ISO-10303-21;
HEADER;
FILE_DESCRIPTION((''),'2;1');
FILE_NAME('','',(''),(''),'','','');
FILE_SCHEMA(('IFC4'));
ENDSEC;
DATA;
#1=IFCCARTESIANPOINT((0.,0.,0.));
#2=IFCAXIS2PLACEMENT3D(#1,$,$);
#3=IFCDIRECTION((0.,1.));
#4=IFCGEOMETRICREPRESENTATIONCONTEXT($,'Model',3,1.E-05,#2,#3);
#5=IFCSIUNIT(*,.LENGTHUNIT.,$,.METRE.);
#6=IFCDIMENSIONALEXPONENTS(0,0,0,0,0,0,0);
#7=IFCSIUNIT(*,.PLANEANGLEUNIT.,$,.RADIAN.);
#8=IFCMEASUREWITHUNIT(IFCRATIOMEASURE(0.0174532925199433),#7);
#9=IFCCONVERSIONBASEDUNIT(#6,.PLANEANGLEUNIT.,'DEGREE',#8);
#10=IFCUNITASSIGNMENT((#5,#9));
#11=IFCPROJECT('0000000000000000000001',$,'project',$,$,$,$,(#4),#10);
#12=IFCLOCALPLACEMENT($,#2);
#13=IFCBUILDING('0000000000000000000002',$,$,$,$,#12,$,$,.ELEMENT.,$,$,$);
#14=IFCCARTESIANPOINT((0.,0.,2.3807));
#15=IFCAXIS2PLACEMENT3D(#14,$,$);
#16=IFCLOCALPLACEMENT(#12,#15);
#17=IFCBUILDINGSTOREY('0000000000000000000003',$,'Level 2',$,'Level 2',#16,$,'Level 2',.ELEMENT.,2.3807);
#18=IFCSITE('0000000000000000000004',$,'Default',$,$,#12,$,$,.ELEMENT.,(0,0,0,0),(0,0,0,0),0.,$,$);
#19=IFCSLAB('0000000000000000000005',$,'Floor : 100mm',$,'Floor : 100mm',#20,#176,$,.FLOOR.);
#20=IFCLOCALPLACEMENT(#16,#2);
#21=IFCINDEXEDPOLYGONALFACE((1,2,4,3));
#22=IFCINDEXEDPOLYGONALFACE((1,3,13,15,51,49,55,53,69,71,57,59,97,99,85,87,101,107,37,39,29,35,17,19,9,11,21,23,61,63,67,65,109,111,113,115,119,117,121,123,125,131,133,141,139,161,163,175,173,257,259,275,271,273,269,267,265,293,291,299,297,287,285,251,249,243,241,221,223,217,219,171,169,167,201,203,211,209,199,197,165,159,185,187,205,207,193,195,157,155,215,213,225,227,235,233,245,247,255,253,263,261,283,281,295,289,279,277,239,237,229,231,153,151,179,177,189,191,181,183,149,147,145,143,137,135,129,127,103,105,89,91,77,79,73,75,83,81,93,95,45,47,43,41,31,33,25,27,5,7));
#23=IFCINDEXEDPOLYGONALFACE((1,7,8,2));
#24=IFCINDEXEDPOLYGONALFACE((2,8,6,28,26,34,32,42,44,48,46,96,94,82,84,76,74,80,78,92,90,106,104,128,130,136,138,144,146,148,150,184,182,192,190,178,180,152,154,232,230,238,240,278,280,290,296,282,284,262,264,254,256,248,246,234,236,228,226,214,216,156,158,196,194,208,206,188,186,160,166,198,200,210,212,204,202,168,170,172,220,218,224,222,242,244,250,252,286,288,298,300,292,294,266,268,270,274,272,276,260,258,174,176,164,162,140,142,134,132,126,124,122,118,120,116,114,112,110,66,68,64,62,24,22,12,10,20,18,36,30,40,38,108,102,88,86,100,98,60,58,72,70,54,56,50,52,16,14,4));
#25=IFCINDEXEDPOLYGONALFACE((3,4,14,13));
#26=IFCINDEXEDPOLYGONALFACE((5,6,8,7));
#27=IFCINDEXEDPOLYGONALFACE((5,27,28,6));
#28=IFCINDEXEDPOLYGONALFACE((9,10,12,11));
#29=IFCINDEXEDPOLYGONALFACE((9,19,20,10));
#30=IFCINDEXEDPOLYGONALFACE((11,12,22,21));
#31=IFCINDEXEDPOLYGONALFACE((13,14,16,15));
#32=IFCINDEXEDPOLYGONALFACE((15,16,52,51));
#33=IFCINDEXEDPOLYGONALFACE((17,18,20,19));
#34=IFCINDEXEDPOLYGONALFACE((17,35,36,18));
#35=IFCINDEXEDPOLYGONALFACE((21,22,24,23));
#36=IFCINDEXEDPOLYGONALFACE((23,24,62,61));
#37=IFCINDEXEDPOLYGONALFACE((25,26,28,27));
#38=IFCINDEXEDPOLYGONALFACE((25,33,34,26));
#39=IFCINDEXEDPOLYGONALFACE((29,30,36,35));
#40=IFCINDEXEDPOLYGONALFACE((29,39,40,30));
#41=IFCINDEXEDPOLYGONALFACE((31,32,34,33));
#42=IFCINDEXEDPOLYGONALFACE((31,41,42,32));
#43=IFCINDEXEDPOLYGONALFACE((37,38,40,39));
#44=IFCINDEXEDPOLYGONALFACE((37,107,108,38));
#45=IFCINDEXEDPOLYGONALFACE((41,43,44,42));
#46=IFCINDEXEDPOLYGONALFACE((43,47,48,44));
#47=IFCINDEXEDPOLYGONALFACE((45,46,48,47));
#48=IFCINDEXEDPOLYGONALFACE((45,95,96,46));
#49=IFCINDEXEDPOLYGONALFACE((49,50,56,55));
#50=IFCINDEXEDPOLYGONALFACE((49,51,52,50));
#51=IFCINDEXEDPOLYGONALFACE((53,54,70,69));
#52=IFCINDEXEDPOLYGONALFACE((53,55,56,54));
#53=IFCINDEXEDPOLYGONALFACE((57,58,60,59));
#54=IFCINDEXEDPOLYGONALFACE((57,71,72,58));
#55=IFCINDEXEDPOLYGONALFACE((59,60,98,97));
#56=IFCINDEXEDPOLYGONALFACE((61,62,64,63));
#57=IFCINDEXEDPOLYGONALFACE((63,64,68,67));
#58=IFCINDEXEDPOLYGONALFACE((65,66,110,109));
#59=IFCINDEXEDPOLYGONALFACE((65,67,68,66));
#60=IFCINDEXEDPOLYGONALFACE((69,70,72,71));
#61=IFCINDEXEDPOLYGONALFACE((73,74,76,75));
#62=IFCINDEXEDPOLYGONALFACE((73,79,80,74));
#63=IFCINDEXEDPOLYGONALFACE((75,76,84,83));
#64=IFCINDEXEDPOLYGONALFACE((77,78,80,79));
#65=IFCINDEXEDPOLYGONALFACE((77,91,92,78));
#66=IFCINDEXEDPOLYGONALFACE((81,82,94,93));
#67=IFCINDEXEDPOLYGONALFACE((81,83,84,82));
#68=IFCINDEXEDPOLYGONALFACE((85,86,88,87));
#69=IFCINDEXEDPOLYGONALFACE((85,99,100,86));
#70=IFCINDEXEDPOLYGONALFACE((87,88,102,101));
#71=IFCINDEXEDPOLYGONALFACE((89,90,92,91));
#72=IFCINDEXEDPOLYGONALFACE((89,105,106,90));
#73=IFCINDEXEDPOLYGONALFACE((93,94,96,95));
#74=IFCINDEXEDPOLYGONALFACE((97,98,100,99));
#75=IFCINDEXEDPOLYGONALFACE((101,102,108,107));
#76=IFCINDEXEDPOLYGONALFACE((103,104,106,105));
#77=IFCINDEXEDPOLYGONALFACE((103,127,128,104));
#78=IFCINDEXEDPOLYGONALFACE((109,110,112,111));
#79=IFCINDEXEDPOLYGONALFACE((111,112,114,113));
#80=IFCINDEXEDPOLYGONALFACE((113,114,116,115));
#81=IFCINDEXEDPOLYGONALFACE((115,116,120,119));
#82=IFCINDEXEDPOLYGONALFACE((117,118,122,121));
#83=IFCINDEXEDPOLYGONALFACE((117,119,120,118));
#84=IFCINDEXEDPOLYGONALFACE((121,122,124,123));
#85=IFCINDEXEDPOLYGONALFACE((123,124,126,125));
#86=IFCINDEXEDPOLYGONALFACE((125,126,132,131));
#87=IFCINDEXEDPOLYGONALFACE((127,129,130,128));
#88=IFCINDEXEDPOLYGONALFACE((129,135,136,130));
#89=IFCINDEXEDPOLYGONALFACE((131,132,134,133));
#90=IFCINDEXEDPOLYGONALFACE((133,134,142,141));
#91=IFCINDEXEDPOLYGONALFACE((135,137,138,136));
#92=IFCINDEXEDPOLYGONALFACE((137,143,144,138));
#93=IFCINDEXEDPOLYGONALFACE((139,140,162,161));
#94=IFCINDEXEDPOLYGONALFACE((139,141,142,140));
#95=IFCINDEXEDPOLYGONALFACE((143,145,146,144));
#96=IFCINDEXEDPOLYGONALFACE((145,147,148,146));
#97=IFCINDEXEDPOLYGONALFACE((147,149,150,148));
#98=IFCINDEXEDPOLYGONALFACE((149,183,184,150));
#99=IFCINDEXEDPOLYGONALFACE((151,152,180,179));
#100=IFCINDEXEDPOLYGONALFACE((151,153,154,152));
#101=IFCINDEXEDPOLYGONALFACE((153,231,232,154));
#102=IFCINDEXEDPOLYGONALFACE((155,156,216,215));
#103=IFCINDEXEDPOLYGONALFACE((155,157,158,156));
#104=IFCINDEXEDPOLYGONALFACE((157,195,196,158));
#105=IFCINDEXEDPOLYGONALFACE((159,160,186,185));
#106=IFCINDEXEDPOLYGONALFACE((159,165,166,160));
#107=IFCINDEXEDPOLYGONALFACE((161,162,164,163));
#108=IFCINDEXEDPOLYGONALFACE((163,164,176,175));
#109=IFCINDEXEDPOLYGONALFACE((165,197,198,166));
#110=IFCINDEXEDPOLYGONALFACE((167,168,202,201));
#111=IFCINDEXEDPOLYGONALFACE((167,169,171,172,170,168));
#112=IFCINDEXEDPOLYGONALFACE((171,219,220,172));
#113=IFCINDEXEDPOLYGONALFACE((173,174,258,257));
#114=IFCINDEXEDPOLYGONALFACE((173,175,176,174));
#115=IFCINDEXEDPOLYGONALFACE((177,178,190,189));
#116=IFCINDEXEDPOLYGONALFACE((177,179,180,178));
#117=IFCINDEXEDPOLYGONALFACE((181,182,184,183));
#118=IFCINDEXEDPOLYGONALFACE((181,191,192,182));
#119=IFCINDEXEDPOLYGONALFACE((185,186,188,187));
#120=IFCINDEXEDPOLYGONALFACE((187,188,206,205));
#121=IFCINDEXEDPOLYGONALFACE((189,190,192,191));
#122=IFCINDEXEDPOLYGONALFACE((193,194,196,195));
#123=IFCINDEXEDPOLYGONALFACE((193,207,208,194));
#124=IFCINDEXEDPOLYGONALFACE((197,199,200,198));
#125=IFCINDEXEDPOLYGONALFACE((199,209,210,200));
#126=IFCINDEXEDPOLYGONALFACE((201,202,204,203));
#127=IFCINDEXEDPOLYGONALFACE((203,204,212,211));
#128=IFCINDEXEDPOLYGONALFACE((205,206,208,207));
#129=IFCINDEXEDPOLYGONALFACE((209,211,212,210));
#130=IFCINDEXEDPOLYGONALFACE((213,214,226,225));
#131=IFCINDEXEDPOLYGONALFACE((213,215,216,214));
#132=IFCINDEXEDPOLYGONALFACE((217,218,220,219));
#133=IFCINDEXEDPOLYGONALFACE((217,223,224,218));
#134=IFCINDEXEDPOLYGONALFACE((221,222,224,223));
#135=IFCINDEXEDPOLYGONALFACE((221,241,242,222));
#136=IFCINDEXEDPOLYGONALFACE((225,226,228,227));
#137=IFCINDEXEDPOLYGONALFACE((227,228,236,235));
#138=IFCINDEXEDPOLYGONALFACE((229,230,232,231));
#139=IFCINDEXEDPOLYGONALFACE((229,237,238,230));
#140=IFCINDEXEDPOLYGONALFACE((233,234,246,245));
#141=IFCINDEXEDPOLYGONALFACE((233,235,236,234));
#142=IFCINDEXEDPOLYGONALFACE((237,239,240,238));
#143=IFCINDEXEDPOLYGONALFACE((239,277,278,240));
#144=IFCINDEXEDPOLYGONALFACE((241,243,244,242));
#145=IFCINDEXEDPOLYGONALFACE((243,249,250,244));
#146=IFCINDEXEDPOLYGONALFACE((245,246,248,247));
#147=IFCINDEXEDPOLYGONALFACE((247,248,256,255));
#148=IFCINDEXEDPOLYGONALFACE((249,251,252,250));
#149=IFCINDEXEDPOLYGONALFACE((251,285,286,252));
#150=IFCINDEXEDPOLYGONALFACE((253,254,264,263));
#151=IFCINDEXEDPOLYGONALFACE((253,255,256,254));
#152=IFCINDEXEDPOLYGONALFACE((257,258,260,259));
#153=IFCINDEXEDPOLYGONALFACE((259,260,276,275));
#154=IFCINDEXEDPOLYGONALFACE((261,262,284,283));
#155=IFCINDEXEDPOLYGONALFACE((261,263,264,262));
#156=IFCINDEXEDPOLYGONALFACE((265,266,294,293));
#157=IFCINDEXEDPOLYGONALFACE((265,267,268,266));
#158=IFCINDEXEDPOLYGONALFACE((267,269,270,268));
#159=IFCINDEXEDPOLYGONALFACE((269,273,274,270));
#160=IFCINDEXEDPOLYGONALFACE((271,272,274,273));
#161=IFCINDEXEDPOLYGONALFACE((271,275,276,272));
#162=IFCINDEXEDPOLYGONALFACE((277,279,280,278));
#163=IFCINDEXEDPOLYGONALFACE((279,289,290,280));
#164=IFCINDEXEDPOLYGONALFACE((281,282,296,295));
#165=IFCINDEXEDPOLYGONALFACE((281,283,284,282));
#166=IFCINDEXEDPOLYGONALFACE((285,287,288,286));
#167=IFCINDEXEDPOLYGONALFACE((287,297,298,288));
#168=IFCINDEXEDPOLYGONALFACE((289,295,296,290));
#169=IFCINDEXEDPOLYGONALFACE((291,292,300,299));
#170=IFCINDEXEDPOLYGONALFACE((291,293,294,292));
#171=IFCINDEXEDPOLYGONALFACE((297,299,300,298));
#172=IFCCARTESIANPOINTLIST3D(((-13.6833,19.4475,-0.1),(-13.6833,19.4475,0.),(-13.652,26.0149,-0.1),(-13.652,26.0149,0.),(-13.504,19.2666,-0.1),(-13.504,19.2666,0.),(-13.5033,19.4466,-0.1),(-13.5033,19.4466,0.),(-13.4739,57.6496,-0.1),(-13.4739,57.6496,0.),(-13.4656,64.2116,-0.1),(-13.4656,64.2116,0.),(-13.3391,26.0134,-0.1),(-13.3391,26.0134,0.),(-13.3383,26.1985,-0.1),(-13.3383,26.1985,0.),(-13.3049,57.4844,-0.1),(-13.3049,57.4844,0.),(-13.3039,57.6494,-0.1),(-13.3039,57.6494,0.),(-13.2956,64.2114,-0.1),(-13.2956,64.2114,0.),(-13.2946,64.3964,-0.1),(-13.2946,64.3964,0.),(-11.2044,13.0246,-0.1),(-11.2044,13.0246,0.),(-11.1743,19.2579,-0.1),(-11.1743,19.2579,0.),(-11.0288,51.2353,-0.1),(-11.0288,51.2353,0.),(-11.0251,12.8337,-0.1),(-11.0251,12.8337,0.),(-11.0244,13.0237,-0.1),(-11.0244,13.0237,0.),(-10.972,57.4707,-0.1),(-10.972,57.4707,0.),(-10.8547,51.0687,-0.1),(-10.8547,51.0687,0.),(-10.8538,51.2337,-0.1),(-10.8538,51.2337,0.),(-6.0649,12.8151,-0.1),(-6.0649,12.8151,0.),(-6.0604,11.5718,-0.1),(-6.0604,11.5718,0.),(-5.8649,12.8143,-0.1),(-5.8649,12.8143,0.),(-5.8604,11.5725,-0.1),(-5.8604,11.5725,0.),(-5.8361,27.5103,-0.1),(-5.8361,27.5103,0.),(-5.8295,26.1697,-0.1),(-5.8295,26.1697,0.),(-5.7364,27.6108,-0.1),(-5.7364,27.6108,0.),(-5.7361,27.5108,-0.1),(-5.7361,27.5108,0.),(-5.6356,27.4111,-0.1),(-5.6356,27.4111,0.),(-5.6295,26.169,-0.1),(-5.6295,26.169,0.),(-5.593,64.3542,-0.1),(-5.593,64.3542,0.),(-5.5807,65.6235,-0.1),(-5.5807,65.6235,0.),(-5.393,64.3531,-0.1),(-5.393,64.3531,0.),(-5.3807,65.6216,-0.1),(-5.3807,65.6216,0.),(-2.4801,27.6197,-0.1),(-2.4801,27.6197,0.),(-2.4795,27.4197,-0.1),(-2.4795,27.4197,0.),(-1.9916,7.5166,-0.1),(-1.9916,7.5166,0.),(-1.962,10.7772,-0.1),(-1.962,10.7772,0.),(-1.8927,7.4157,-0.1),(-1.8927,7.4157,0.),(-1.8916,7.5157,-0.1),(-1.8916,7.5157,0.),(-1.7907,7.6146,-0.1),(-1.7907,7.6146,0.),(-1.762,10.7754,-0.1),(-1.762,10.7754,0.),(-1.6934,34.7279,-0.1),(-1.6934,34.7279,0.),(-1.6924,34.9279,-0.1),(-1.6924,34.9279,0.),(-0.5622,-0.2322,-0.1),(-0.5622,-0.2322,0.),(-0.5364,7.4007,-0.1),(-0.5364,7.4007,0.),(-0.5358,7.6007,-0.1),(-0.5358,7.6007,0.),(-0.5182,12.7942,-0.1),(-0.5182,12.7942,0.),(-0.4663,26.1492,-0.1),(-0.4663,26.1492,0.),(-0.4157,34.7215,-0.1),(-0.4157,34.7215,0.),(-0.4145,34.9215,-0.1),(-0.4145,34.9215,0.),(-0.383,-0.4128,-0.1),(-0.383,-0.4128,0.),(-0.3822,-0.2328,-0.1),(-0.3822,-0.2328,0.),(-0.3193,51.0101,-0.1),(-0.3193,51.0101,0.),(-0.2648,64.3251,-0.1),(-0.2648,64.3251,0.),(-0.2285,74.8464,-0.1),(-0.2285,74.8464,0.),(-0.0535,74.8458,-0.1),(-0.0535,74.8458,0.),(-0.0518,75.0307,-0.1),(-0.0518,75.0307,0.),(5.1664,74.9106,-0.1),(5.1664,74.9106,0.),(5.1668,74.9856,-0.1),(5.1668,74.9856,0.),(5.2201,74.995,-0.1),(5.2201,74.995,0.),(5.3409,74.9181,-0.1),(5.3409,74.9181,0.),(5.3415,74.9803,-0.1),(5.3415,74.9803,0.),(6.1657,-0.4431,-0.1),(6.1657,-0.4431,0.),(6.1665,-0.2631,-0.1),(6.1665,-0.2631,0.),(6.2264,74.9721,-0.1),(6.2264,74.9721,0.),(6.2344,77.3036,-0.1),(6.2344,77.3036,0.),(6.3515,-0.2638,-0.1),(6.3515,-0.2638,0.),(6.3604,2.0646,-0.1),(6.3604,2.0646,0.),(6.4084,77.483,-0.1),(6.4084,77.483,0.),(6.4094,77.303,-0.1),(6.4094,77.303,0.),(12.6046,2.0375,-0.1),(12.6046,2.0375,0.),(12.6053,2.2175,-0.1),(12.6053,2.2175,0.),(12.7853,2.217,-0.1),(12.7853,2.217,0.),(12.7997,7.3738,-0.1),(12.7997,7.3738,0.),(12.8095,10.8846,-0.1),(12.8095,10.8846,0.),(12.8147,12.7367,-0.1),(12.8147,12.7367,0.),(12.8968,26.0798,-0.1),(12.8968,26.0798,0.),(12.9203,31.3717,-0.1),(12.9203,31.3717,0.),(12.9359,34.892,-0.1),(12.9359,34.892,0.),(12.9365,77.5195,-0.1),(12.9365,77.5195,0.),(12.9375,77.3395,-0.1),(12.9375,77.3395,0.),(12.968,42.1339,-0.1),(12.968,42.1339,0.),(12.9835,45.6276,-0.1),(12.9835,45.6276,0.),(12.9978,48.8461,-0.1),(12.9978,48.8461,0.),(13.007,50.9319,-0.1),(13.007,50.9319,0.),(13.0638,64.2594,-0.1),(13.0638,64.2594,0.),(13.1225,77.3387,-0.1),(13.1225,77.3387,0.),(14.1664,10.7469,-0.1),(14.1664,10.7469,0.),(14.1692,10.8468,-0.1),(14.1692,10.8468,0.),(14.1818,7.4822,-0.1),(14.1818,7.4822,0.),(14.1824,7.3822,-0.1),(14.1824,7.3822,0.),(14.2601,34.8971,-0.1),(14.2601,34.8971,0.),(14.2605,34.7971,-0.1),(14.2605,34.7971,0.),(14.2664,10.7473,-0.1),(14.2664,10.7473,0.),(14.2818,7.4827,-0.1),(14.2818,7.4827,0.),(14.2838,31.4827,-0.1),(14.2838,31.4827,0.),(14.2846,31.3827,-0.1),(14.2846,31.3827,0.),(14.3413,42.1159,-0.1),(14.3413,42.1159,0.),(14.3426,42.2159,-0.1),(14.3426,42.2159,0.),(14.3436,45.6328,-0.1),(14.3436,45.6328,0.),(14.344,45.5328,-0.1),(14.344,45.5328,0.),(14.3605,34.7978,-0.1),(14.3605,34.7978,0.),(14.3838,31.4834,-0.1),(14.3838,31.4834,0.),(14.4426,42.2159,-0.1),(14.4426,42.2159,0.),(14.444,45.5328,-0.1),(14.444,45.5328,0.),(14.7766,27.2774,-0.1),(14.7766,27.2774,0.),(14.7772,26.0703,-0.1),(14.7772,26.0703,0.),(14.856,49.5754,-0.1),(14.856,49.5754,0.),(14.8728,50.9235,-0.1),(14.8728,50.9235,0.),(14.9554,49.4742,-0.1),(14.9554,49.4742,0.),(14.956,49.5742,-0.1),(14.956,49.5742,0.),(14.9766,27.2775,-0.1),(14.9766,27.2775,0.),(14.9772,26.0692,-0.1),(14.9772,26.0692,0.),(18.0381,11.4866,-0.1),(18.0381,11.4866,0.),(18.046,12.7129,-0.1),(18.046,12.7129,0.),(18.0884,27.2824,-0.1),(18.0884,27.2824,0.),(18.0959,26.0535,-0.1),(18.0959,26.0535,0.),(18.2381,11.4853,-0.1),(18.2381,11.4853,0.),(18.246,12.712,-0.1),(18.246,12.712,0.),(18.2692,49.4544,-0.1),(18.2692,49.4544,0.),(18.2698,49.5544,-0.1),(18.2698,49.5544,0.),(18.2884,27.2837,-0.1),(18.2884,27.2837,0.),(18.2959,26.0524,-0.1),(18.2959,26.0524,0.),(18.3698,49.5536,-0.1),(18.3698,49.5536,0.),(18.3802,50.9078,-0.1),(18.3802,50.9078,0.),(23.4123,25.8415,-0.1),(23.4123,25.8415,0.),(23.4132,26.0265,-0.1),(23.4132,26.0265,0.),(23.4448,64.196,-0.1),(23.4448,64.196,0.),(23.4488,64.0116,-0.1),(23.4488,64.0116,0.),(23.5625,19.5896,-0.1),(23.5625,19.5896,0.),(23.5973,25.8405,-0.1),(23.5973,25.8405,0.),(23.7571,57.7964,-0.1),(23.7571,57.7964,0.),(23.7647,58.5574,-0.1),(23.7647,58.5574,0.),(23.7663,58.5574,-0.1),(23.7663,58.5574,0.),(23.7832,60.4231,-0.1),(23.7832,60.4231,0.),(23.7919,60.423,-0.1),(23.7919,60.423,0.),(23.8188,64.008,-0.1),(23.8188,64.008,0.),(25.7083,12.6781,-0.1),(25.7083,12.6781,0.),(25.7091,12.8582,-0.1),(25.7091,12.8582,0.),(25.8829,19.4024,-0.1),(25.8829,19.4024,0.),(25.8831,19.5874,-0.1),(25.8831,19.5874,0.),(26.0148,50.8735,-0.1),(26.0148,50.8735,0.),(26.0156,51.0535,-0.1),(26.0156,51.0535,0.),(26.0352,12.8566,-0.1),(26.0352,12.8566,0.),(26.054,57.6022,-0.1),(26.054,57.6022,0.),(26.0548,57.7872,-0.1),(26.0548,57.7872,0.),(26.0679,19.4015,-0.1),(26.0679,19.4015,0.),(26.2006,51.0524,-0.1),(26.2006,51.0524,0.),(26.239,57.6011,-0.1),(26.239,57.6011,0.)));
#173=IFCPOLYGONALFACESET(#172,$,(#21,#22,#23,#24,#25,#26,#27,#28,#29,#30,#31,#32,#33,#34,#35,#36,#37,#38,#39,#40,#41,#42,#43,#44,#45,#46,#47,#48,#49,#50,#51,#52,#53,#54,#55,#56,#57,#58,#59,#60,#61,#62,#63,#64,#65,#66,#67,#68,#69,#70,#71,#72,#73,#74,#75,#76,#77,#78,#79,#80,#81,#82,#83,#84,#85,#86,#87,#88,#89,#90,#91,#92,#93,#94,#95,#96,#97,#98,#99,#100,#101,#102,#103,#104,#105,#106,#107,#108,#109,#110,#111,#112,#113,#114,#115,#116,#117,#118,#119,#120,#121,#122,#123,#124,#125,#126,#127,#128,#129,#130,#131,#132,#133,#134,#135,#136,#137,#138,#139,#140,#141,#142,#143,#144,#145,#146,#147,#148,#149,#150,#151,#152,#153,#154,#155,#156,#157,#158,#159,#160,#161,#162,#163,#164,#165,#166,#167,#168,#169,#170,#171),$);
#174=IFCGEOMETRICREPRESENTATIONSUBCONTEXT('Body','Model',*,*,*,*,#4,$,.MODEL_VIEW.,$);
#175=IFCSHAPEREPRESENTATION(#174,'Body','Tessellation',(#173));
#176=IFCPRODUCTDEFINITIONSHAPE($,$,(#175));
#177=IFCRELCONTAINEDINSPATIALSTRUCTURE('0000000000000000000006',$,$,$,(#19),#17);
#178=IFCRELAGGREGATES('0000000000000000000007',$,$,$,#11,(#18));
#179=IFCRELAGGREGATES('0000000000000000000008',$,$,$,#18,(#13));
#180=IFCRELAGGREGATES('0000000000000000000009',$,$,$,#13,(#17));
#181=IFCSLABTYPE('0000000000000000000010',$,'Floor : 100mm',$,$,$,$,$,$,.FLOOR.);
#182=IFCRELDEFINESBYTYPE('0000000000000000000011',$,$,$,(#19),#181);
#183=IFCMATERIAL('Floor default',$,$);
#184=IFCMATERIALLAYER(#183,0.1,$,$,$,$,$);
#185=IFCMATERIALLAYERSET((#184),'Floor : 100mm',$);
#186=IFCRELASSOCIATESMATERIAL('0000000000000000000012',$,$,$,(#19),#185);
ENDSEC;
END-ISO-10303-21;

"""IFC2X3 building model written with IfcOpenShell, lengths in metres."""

from ifc_helpers import new_model, entity, si_unit, converted_unit, direction, frame, origin, place, context, subcontext, project, spatial, polyline, outline, extrude, material, layer, layer_set, layer_usage, type_object, element, save


model = new_model("IFC2X3")

# Units and contexts
model_context = context("Model", 3, precision=1e-05, world=origin(), true_north=direction((0.0, 1.0)))
body_context = subcontext(model_context, "Body", "Model", "MODEL_VIEW")
ifc_project = project(units=[si_unit("LENGTHUNIT", "METRE"), converted_unit("PLANEANGLEUNIT", "DEGREE", entity("IfcRatioMeasure", 0.0174532925199433), si_unit("PLANEANGLEUNIT", "RADIAN"), dimensions=[0, 0, 0, 0, 0, 0, 0])], contexts=[model_context])

# Site, building, storey
placement = place(None, origin())
site = spatial("IfcSite", under=ifc_project, at=placement, Name="Default", CompositionType="ELEMENT", RefLatitude=(0, 0, 0, 0), RefLongitude=(0, 0, 0, 0), RefElevation=0.0)
building = spatial("IfcBuilding", under=site, at=placement, CompositionType="ELEMENT")
storey_placement = place(placement, frame((0.0, 0.0, 2.3807)))
storey = spatial("IfcBuildingStorey", under=building, at=storey_placement, Name="Level 2", ObjectType="Level 2", LongName="Level 2", CompositionType="ELEMENT", Elevation=2.3807)

# Slab
ifc_material_1 = material(Name="Floor default")
ifc_layer_1 = layer(ifc_material_1, 0.1)
ifc_layer_set_1 = layer_set([ifc_layer_1], Name="Floor : 100mm")
ifc_layer_usage_1 = layer_usage(ifc_layer_set_1, "AXIS3", "POSITIVE", 0.0)
slab_type = type_object("IfcSlabType", Name="Floor : 100mm", PredefinedType="FLOOR")
slab_placement = place(storey_placement, origin())
element("IfcSlab", 1, at=slab_placement, inside=storey, type_object=slab_type, material=ifc_layer_usage_1, Name="Floor : 100mm", ObjectType="Floor : 100mm", PredefinedType="FLOOR", context=body_context, shape_type="SweptSolid", body=[
    extrude(outline(polyline([(-13.6833, 19.4475), (-13.5033, 19.4466), (-13.504, 19.2666), (-11.1743, 19.2579), (-11.2044, 13.0246), (-11.0244, 13.0237), (-11.0251, 12.8337), (-6.0649, 12.8151), (-6.0604, 11.5718), (-5.8604, 11.5725), (-5.8649, 12.8143), (-0.5182, 12.7942), (-0.5358, 7.6007), (-1.7907, 7.6146), (-1.762, 10.7754), (-1.962, 10.7772), (-1.9916, 7.5166), (-1.8916, 7.5157), (-1.8927, 7.4157), (-0.5364, 7.4007), (-0.5622, -0.2322), (-0.3822, -0.2328), (-0.383, -0.4128), (6.1657, -0.4431), (6.1665, -0.2631), (6.3515, -0.2638), (6.3604, 2.0646), (12.6046, 2.0375), (12.6053, 2.2175), (12.7853, 2.217), (12.7997, 7.3738), (14.1824, 7.3822), (14.1818, 7.4822), (14.2818, 7.4827), (14.2664, 10.7473), (14.1664, 10.7469), (14.1692, 10.8468), (12.8095, 10.8846), (12.8147, 12.7367), (18.046, 12.7129), (18.0381, 11.4866), (18.2381, 11.4853), (18.246, 12.712), (25.7083, 12.6781), (25.7091, 12.8582), (26.0352, 12.8566), (26.0679, 19.4015), (25.8829, 19.4024), (25.8831, 19.5874), (23.5625, 19.5896), (23.5973, 25.8405), (23.4123, 25.8415), (23.4132, 26.0265), (18.2959, 26.0524), (18.2884, 27.2837), (18.0884, 27.2824), (18.0959, 26.0535), (14.9772, 26.0692), (14.9766, 27.2775), (14.7766, 27.2774), (14.7772, 26.0703), (12.8968, 26.0798), (12.9203, 31.3717), (14.2846, 31.3827), (14.2838, 31.4827), (14.3838, 31.4834), (14.3605, 34.7978), (14.2605, 34.7971), (14.2601, 34.8971), (12.9359, 34.892), (12.968, 42.1339), (14.3413, 42.1159), (14.3426, 42.2159), (14.4426, 42.2159), (14.444, 45.5328), (14.344, 45.5328), (14.3436, 45.6328), (12.9835, 45.6276), (12.9978, 48.8461), (13.007, 50.9319), (14.8728, 50.9235), (14.856, 49.5754), (14.956, 49.5742), (14.9554, 49.4742), (18.2692, 49.4544), (18.2698, 49.5544), (18.3698, 49.5536), (18.3802, 50.9078), (26.0148, 50.8735), (26.0156, 51.0535), (26.2006, 51.0524), (26.239, 57.6011), (26.054, 57.6022), (26.0548, 57.7872), (23.7571, 57.7964), (23.7647, 58.5574), (23.7663, 58.5574), (23.7919, 60.423), (23.7832, 60.4231), (23.8188, 64.008), (23.4488, 64.0116), (23.4448, 64.196), (13.0638, 64.2594), (13.1225, 77.3387), (12.9375, 77.3395), (12.9365, 77.5195), (6.4084, 77.483), (6.4094, 77.303), (6.2344, 77.3036), (6.2264, 74.9721), (5.3415, 74.9803), (5.3409, 74.9181), (5.2201, 74.995), (5.1664, 74.9106), (5.1668, 74.9856), (-0.0518, 75.0307), (-0.0535, 74.8458), (-0.2285, 74.8464), (-0.2648, 64.3251), (-5.393, 64.3531), (-5.3807, 65.6216), (-5.5807, 65.6235), (-5.593, 64.3542), (-13.2946, 64.3964), (-13.2956, 64.2114), (-13.4656, 64.2116), (-13.4739, 57.6496), (-13.3039, 57.6494), (-13.3049, 57.4844), (-10.972, 57.4707), (-11.0288, 51.2353), (-10.8538, 51.2337), (-10.8547, 51.0687), (-0.3193, 51.0101), (-0.4145, 34.9215), (-1.6924, 34.9279), (-1.6934, 34.7279), (-0.4157, 34.7215), (-0.4663, 26.1492), (-5.6295, 26.169), (-5.6356, 27.4111), (-2.4795, 27.4197), (-2.4801, 27.6197), (-5.7364, 27.6108), (-5.7361, 27.5108), (-5.8361, 27.5103), (-5.8295, 26.1697), (-13.3383, 26.1985), (-13.3391, 26.0134), (-13.652, 26.0149), (-13.6833, 19.4475)])), frame((0.0, 0.0, -0.1), z_axis=(0.0, 0.0, 1.0), x_axis=(1.0, 0.0, 0.0)), (0.0, 0.0, 1.0), 0.1),
])

save(model, "model.ifc")
